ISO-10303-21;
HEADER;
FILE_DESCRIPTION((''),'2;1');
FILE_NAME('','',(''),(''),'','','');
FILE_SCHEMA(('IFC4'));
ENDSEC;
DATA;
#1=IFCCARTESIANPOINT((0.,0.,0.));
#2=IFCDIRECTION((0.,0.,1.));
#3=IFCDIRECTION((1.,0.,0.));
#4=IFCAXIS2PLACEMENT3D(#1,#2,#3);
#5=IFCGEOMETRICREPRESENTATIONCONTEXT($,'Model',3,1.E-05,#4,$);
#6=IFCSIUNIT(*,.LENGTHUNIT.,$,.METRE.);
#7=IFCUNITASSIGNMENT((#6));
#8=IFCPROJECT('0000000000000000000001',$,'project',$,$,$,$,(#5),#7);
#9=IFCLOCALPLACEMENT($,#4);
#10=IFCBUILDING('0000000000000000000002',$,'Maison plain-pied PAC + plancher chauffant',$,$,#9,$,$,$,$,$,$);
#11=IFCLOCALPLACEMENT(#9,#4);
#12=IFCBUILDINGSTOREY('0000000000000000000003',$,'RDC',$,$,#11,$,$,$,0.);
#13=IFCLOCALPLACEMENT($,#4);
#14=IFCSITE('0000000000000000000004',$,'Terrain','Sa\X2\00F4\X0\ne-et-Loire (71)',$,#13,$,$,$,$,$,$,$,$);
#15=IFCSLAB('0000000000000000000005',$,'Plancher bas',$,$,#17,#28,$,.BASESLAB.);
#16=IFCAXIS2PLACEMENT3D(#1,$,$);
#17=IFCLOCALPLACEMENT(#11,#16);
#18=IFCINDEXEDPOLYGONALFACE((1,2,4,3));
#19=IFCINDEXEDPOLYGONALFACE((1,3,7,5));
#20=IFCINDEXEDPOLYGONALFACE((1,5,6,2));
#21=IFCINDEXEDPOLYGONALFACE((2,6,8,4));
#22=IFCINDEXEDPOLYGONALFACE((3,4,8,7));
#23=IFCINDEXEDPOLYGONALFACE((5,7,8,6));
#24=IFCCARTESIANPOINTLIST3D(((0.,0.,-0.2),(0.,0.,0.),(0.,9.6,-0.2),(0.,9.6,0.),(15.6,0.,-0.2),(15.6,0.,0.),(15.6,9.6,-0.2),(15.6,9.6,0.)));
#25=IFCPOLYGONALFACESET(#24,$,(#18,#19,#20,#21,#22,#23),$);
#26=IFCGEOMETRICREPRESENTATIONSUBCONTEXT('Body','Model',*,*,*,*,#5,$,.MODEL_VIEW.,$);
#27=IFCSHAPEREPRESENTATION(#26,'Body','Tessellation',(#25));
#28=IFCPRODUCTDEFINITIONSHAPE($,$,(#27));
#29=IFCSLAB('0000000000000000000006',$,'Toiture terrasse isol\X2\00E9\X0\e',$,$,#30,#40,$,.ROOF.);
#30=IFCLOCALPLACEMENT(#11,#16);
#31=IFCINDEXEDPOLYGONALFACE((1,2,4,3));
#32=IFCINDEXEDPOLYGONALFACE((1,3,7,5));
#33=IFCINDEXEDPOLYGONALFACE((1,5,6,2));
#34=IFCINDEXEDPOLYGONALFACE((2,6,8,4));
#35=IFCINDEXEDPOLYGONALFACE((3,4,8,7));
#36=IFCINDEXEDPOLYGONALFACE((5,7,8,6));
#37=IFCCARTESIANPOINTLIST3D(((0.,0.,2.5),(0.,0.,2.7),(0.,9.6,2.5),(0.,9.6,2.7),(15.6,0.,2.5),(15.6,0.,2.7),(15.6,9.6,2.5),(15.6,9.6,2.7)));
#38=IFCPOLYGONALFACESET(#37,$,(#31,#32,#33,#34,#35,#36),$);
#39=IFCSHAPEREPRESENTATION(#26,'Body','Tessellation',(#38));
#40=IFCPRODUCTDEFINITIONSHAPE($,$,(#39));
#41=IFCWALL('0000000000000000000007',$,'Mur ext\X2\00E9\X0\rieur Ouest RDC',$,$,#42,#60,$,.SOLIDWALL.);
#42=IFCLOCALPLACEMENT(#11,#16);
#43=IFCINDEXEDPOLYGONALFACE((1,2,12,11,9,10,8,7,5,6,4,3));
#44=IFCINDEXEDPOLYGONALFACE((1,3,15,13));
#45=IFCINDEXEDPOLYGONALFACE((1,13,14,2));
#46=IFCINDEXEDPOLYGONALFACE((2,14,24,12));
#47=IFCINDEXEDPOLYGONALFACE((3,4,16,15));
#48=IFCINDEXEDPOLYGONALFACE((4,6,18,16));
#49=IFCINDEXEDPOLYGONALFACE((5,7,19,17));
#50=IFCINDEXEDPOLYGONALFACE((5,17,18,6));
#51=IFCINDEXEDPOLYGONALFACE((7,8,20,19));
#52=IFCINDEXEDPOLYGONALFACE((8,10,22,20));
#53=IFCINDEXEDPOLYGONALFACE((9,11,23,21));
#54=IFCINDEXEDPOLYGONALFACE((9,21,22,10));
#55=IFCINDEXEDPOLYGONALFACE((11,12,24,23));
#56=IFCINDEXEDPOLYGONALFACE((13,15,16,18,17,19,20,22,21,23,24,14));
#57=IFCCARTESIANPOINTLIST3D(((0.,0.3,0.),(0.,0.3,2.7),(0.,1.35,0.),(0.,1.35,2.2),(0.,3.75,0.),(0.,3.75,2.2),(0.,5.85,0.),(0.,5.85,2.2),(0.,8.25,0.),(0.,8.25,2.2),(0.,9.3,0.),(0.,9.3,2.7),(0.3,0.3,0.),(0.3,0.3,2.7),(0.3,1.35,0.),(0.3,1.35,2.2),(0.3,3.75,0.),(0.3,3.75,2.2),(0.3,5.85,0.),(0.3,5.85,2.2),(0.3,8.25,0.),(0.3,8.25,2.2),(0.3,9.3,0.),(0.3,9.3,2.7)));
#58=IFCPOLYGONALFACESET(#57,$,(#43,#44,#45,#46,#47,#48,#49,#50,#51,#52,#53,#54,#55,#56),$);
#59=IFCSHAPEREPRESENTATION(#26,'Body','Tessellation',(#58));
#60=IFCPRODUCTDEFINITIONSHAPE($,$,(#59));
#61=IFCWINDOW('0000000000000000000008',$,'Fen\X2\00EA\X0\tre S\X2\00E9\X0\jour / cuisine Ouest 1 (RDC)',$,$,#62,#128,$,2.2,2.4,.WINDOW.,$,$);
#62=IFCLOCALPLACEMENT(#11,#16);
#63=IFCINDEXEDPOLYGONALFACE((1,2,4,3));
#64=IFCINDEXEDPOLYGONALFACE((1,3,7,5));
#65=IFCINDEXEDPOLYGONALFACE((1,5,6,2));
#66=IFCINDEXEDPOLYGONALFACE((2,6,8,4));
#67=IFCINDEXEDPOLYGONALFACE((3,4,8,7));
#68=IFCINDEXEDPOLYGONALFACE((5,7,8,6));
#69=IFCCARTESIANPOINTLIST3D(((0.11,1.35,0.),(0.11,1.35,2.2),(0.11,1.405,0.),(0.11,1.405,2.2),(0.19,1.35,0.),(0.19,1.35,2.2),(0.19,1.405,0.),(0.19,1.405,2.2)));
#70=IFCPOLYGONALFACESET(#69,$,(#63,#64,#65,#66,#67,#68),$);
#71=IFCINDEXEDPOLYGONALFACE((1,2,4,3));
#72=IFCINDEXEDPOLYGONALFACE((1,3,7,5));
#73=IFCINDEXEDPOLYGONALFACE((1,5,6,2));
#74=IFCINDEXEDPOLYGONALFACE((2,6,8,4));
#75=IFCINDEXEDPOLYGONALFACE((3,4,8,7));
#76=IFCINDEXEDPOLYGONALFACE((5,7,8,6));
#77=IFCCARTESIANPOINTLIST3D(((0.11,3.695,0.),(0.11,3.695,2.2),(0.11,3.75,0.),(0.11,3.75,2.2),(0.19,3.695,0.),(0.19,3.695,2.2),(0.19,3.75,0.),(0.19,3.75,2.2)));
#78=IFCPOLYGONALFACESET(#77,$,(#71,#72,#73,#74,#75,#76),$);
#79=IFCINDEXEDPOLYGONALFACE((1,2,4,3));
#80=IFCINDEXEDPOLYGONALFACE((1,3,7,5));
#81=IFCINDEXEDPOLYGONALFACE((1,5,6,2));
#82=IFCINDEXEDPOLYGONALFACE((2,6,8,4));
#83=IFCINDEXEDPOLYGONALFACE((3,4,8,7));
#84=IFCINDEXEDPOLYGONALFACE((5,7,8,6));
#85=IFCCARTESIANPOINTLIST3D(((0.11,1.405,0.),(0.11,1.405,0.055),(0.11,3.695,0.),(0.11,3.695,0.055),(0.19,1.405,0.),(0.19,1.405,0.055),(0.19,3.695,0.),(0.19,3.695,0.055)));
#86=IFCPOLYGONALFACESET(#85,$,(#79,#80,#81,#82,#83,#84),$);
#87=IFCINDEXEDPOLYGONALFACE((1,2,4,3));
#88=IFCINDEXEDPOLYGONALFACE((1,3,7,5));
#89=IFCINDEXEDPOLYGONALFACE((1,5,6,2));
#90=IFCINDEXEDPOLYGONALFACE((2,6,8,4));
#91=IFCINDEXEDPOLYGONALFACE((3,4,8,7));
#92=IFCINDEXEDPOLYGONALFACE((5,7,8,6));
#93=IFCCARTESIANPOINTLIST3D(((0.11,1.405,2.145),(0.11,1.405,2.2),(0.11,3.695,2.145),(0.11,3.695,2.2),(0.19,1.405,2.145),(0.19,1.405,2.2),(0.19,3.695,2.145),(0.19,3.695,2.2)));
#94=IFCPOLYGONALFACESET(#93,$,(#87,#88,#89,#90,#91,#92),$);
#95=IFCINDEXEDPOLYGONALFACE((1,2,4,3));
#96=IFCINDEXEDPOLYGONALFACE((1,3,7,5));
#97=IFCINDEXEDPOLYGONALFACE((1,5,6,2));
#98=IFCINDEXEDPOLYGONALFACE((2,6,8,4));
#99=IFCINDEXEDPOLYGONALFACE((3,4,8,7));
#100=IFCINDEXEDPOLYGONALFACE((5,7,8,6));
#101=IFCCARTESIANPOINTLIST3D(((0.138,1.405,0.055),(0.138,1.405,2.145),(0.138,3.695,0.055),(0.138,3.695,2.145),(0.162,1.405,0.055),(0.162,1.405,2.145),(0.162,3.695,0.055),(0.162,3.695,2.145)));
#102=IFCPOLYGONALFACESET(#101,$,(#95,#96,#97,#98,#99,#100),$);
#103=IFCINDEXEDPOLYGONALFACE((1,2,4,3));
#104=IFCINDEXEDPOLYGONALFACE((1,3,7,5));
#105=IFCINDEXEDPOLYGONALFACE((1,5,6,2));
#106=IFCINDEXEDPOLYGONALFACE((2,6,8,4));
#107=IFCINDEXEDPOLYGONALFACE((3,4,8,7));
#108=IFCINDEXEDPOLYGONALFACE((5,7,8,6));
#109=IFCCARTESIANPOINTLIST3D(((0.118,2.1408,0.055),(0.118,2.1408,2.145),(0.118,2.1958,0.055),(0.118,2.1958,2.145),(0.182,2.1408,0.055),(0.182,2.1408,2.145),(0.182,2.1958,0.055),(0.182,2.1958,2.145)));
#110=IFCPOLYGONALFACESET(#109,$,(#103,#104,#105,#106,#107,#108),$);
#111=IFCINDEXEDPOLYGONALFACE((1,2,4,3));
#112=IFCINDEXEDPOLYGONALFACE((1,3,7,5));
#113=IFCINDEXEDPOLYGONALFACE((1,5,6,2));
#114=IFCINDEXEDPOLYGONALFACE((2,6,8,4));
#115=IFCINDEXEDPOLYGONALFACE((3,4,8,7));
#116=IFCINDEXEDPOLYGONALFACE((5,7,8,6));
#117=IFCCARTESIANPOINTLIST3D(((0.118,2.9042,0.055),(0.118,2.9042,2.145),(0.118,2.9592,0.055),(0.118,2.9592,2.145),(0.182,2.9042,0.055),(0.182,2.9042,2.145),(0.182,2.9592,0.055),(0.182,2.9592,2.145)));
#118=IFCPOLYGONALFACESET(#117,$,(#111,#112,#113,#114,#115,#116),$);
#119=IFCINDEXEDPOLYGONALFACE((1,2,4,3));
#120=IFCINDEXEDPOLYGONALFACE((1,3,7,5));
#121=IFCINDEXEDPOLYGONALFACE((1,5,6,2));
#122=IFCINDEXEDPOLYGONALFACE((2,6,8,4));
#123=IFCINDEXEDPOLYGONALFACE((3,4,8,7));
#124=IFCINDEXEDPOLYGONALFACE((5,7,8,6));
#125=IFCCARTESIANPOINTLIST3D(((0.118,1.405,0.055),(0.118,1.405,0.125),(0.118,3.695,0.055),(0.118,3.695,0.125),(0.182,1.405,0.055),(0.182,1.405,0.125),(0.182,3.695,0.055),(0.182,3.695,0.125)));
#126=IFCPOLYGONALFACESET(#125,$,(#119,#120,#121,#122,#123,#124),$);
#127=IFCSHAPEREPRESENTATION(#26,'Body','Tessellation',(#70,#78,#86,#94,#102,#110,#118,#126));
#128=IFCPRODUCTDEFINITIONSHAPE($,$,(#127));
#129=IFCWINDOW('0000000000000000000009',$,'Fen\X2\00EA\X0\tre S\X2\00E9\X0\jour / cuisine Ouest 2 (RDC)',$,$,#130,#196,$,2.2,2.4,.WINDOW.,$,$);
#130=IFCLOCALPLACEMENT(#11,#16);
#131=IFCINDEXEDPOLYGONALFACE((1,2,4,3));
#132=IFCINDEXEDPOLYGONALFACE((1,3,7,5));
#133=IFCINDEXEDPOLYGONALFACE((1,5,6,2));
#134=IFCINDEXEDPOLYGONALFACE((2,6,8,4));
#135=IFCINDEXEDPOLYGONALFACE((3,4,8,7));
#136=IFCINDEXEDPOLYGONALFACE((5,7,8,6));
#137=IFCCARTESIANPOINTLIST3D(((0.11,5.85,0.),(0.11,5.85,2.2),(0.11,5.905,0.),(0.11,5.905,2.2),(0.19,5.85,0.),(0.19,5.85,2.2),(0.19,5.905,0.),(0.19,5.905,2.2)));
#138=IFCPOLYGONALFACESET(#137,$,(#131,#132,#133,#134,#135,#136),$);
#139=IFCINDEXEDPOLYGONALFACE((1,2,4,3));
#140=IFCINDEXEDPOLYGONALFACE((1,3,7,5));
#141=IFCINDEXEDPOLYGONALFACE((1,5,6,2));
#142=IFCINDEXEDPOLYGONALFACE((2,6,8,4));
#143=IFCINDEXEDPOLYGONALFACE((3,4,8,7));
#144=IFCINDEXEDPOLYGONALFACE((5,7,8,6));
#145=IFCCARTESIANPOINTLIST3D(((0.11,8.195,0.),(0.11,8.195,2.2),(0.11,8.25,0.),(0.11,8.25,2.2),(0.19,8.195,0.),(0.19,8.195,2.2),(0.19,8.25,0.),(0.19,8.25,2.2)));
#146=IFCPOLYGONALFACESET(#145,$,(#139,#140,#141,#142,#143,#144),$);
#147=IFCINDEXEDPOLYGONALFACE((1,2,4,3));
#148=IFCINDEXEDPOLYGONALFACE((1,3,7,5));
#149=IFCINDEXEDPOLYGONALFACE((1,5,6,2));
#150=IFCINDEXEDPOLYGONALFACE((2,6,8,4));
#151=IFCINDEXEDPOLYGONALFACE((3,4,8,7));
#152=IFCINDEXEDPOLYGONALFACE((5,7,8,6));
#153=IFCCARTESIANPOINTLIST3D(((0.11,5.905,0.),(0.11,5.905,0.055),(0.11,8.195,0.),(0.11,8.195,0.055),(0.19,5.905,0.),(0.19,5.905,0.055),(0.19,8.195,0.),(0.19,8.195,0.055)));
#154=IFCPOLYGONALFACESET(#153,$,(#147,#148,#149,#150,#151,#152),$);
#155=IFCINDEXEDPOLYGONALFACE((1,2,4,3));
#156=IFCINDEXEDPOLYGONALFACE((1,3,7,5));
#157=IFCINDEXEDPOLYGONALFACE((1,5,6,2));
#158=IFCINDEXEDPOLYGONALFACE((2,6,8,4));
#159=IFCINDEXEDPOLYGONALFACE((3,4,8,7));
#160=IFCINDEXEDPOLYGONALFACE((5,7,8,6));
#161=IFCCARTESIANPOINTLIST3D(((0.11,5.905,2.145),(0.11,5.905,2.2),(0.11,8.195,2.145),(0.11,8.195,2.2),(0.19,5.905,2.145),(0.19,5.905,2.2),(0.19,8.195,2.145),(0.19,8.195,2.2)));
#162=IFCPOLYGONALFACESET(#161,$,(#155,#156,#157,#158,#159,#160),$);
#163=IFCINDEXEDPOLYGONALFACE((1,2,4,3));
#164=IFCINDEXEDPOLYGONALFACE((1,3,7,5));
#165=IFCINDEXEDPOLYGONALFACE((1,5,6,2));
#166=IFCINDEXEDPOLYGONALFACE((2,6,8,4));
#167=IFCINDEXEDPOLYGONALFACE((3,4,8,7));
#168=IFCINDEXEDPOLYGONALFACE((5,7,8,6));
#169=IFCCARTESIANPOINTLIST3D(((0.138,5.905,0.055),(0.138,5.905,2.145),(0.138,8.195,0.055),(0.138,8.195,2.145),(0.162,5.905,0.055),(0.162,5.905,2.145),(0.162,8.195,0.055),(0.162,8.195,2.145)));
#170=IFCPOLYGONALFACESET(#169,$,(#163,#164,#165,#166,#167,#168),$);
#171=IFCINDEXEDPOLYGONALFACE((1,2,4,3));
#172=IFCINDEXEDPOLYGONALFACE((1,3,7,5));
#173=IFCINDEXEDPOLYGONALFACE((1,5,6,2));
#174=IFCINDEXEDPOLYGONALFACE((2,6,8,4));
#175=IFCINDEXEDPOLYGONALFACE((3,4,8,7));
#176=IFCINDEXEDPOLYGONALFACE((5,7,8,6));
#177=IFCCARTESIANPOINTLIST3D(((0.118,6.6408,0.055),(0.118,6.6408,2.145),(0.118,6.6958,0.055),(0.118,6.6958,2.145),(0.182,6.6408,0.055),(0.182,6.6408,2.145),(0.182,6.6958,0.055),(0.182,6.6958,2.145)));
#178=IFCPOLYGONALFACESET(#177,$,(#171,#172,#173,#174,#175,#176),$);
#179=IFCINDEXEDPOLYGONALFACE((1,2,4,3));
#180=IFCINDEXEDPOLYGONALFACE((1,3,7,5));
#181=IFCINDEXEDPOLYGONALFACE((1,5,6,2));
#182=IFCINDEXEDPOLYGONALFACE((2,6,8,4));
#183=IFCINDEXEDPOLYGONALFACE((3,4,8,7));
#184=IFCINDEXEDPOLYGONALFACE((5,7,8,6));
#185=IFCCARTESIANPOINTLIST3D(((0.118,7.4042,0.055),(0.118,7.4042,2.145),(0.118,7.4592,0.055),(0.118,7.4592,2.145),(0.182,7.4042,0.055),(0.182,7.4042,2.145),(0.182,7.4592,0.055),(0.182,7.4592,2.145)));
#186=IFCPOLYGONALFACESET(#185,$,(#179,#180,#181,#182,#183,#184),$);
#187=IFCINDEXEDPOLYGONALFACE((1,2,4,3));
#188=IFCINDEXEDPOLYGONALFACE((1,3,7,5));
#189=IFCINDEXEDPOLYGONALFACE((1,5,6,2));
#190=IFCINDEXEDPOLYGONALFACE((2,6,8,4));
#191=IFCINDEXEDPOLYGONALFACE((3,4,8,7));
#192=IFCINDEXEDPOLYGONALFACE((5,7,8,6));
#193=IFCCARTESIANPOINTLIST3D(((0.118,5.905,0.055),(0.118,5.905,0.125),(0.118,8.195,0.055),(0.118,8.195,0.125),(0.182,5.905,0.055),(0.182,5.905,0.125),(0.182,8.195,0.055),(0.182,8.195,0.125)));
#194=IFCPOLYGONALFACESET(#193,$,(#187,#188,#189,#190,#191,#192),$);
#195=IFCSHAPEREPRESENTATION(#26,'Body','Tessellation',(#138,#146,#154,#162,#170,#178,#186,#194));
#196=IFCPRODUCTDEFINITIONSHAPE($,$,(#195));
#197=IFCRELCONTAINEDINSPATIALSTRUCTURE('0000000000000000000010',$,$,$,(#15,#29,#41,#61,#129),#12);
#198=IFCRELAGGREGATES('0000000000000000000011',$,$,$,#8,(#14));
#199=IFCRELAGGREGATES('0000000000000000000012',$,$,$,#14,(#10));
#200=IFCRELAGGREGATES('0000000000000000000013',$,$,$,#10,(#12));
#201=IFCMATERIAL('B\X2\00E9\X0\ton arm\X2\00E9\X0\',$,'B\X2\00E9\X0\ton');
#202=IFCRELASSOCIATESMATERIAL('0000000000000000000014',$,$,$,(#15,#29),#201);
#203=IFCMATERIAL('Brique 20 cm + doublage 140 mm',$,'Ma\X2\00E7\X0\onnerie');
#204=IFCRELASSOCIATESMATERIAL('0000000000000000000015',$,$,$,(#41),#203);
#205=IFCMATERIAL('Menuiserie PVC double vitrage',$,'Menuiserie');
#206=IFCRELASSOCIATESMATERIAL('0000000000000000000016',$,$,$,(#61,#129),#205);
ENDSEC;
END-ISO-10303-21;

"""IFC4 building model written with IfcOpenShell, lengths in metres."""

from ifc_helpers import new_model, si_unit, frame, frame_2d, origin_with_axes, place, context, subcontext, project, spatial, rectangle, extrude, material, element, fill, save


model = new_model("IFC4")

# Units and contexts
model_context = context("Model", 3, precision=1e-05, world=origin_with_axes())
body_context = subcontext(model_context, "Body", "Model", "MODEL_VIEW")
ifc_project = project(units=[si_unit("LENGTHUNIT", "METRE")], contexts=[model_context])

# Site, building, storey
site_placement = place(None, origin_with_axes())
site = spatial("IfcSite", under=ifc_project, at=site_placement, Name="Terrain", Description="Saône-et-Loire (71)")
building_placement = place(None, origin_with_axes())
building = spatial("IfcBuilding", under=site, at=building_placement, Name="Maison plain-pied PAC + plancher chauffant")
storey_placement = place(building_placement, origin_with_axes())
storey = spatial("IfcBuildingStorey", under=building, at=storey_placement, Name="RDC", Elevation=0.0)

# Slabs
ifc_material_1 = material(Name="Béton armé", Category="Béton")
slab_1_placement = place(storey_placement, frame((0.0, 0.0, -0.2), z_axis=(0.0, 0.0, 1.0), x_axis=(1.0, 0.0, 0.0)))
element("IfcSlab", 1, at=slab_1_placement, inside=storey, material=ifc_material_1, Name="Plancher bas", PredefinedType="BASESLAB", context=body_context, shape_type="SweptSolid", body=[
    extrude(rectangle(XDim=15.6, YDim=9.6, at=frame_2d((7.8, 4.8))), origin_with_axes(), (0.0, 0.0, 1.0), 0.2),
])
slab_2_placement = place(storey_placement, frame((0.0, 0.0, 2.5), z_axis=(0.0, 0.0, 1.0), x_axis=(1.0, 0.0, 0.0)))
element("IfcSlab", 2, at=slab_2_placement, inside=storey, material=ifc_material_1, Name="Toiture terrasse isolée", PredefinedType="ROOF", context=body_context, shape_type="SweptSolid", body=[
    extrude(rectangle(XDim=15.6, YDim=9.6, at=frame_2d((7.8, 4.8))), origin_with_axes(), (0.0, 0.0, 1.0), 0.2),
])

# Shared definitions
ifc_material_2 = material(Name="Brique 20 cm + doublage 140 mm", Category="Maçonnerie")
ifc_material_3 = material(Name="Menuiserie PVC double vitrage", Category="Menuiserie")

# Wall, openings, windows
wall_1_placement = place(storey_placement, frame((0.0, 0.3, 0.0), z_axis=(0.0, 0.0, 1.0), x_axis=(1.0, 0.0, 0.0)))
wall_1 = element("IfcWall", 3, at=wall_1_placement, inside=storey, material=ifc_material_2, Name="Mur extérieur Ouest RDC", PredefinedType="SOLIDWALL", context=body_context, shape_type="SweptSolid", body=[
    extrude(rectangle(XDim=0.3, YDim=9.0, at=frame_2d((0.15, 4.5))), origin_with_axes(), (0.0, 0.0, 1.0), 2.7),
])
opening_1_placement = place(storey_placement, frame((-0.05, 1.35, 0.0), z_axis=(0.0, 0.0, 1.0), x_axis=(1.0, 0.0, 0.0)))
opening_1 = element("IfcOpeningElement", 4, at=opening_1_placement, cuts=wall_1, context=body_context, shape_type="SweptSolid", body=[
    extrude(rectangle(XDim=0.4, YDim=2.4, at=frame_2d((0.2, 1.2))), origin_with_axes(), (0.0, 0.0, 1.0), 2.2),
])
opening_2_placement = place(storey_placement, frame((-0.05, 5.85, 0.0), z_axis=(0.0, 0.0, 1.0), x_axis=(1.0, 0.0, 0.0)))
opening_2 = element("IfcOpeningElement", 5, at=opening_2_placement, cuts=wall_1, context=body_context, shape_type="SweptSolid", body=[
    extrude(rectangle(XDim=0.4, YDim=2.4, at=frame_2d((0.2, 1.2))), origin_with_axes(), (0.0, 0.0, 1.0), 2.2),
])
window_1_placement = place(storey_placement, frame((0.11, 1.35, 0.0), z_axis=(0.0, 0.0, 1.0), x_axis=(1.0, 0.0, 0.0)))
window_1 = element("IfcWindow", 6, at=window_1_placement, inside=storey, material=ifc_material_3, Name="Fenêtre Séjour / cuisine Ouest 1 (RDC)", OverallHeight=2.2, OverallWidth=2.4, PredefinedType="WINDOW", context=body_context, shape_type="SweptSolid", body=[
    extrude(rectangle(XDim=0.08, YDim=0.055, at=frame_2d((0.04, 0.0275))), origin_with_axes(), (0.0, 0.0, 1.0), 2.2),
    extrude(rectangle(XDim=0.08, YDim=0.055, at=frame_2d((0.04, 0.0275))), frame((0.0, 2.345, 0.0), z_axis=(0.0, 0.0, 1.0), x_axis=(1.0, 0.0, 0.0)), (0.0, 0.0, 1.0), 2.2),
    extrude(rectangle(XDim=0.08, YDim=2.29, at=frame_2d((0.04, 1.145))), frame((0.0, 0.055, 0.0), z_axis=(0.0, 0.0, 1.0), x_axis=(1.0, 0.0, 0.0)), (0.0, 0.0, 1.0), 0.055),
    extrude(rectangle(XDim=0.08, YDim=2.29, at=frame_2d((0.04, 1.145))), frame((0.0, 0.055, 2.145), z_axis=(0.0, 0.0, 1.0), x_axis=(1.0, 0.0, 0.0)), (0.0, 0.0, 1.0), 0.055),
    extrude(rectangle(XDim=0.024, YDim=2.29, at=frame_2d((0.012, 1.145))), frame((0.028, 0.055, 0.055), z_axis=(0.0, 0.0, 1.0), x_axis=(1.0, 0.0, 0.0)), (0.0, 0.0, 1.0), 2.09),
    extrude(rectangle(XDim=0.064, YDim=0.055, at=frame_2d((0.032, 0.0275))), frame((0.008, 0.7908, 0.055), z_axis=(0.0, 0.0, 1.0), x_axis=(1.0, 0.0, 0.0)), (0.0, 0.0, 1.0), 2.09),
    extrude(rectangle(XDim=0.064, YDim=0.055, at=frame_2d((0.032, 0.0275))), frame((0.008, 1.5542, 0.055), z_axis=(0.0, 0.0, 1.0), x_axis=(1.0, 0.0, 0.0)), (0.0, 0.0, 1.0), 2.09),
    extrude(rectangle(XDim=0.064, YDim=2.29, at=frame_2d((0.032, 1.145))), frame((0.008, 0.055, 0.055), z_axis=(0.0, 0.0, 1.0), x_axis=(1.0, 0.0, 0.0)), (0.0, 0.0, 1.0), 0.07),
])
fill(opening_1, window_1)
window_2_placement = place(storey_placement, frame((0.11, 5.85, 0.0), z_axis=(0.0, 0.0, 1.0), x_axis=(1.0, 0.0, 0.0)))
window_2 = element("IfcWindow", 7, at=window_2_placement, inside=storey, material=ifc_material_3, Name="Fenêtre Séjour / cuisine Ouest 2 (RDC)", OverallHeight=2.2, OverallWidth=2.4, PredefinedType="WINDOW", context=body_context, shape_type="SweptSolid", body=[
    extrude(rectangle(XDim=0.08, YDim=0.055, at=frame_2d((0.04, 0.0275))), origin_with_axes(), (0.0, 0.0, 1.0), 2.2),
    extrude(rectangle(XDim=0.08, YDim=0.055, at=frame_2d((0.04, 0.0275))), frame((0.0, 2.345, 0.0), z_axis=(0.0, 0.0, 1.0), x_axis=(1.0, 0.0, 0.0)), (0.0, 0.0, 1.0), 2.2),
    extrude(rectangle(XDim=0.08, YDim=2.29, at=frame_2d((0.04, 1.145))), frame((0.0, 0.055, 0.0), z_axis=(0.0, 0.0, 1.0), x_axis=(1.0, 0.0, 0.0)), (0.0, 0.0, 1.0), 0.055),
    extrude(rectangle(XDim=0.08, YDim=2.29, at=frame_2d((0.04, 1.145))), frame((0.0, 0.055, 2.145), z_axis=(0.0, 0.0, 1.0), x_axis=(1.0, 0.0, 0.0)), (0.0, 0.0, 1.0), 0.055),
    extrude(rectangle(XDim=0.024, YDim=2.29, at=frame_2d((0.012, 1.145))), frame((0.028, 0.055, 0.055), z_axis=(0.0, 0.0, 1.0), x_axis=(1.0, 0.0, 0.0)), (0.0, 0.0, 1.0), 2.09),
    extrude(rectangle(XDim=0.064, YDim=0.055, at=frame_2d((0.032, 0.0275))), frame((0.008, 0.7908, 0.055), z_axis=(0.0, 0.0, 1.0), x_axis=(1.0, 0.0, 0.0)), (0.0, 0.0, 1.0), 2.09),
    extrude(rectangle(XDim=0.064, YDim=0.055, at=frame_2d((0.032, 0.0275))), frame((0.008, 1.5542, 0.055), z_axis=(0.0, 0.0, 1.0), x_axis=(1.0, 0.0, 0.0)), (0.0, 0.0, 1.0), 2.09),
    extrude(rectangle(XDim=0.064, YDim=2.29, at=frame_2d((0.032, 1.145))), frame((0.008, 0.055, 0.055), z_axis=(0.0, 0.0, 1.0), x_axis=(1.0, 0.0, 0.0)), (0.0, 0.0, 1.0), 0.07),
])
fill(opening_2, window_2)

save(model, "model.ifc")
